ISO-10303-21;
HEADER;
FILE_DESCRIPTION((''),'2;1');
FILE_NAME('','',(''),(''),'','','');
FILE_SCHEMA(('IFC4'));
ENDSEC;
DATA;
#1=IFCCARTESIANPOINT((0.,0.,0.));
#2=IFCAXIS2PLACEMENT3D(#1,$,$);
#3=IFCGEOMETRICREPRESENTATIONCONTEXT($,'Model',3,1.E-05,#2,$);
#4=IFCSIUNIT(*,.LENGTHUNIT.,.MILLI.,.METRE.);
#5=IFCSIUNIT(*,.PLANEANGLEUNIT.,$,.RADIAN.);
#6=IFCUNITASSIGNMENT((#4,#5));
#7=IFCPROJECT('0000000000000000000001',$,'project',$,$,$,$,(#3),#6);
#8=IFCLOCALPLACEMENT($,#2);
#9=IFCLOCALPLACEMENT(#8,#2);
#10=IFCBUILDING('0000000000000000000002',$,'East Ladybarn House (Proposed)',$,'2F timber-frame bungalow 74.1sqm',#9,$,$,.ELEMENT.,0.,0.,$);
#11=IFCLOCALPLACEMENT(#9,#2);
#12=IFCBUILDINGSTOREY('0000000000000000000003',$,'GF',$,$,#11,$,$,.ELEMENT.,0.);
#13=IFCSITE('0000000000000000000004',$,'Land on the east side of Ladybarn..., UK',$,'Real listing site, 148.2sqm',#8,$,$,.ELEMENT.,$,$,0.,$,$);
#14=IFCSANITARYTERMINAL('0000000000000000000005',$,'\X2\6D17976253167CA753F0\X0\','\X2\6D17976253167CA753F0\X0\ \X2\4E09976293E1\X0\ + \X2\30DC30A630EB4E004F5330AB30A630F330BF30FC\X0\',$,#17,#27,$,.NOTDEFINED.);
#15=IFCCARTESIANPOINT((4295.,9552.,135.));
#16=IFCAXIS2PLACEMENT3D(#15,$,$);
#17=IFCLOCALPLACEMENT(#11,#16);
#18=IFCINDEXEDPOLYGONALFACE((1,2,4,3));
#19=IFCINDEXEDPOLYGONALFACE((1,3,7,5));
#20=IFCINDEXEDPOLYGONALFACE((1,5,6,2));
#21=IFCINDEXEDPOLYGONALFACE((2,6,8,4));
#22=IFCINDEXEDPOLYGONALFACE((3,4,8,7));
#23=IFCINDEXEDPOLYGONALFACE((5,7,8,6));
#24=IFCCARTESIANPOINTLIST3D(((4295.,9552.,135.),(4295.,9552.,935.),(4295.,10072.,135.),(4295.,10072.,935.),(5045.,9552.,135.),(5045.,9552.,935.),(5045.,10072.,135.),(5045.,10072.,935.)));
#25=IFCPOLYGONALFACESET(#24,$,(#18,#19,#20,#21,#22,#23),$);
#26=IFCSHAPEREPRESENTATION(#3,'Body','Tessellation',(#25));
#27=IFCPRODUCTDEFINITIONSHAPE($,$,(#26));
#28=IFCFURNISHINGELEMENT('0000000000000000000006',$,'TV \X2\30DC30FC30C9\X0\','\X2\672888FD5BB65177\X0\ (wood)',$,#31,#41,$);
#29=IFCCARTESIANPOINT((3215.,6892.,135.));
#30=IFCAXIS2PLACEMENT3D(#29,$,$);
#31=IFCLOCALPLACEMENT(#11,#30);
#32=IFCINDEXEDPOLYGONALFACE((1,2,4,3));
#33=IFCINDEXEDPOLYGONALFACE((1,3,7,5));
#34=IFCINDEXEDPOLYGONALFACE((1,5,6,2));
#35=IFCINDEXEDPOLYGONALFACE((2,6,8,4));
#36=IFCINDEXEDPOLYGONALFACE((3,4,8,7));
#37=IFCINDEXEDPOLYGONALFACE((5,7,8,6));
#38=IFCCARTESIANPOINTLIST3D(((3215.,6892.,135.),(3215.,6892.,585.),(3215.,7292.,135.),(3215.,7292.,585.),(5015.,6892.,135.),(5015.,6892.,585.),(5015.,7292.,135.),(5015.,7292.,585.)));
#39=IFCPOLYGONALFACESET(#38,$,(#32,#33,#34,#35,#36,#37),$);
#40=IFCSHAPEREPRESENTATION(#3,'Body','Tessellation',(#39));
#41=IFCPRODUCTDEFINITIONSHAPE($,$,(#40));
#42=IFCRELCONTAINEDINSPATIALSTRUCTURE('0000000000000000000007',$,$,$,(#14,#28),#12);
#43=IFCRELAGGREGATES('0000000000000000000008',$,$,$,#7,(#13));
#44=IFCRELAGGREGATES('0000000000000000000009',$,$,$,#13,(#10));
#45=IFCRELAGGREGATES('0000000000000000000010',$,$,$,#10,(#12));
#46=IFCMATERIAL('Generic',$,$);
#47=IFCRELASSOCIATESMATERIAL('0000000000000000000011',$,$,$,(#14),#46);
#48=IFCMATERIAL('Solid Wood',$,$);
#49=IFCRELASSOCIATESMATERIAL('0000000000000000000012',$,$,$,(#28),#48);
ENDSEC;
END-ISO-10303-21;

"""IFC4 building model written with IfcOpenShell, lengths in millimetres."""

from ifc_helpers import new_model, si_unit, frame, frame_2d, origin, place, context, project, spatial, rectangle, extrude, material, element, save


model = new_model("IFC4")

# Units and contexts
model_context = context("Model", 3, precision=1e-05, world=origin())
ifc_project = project(units=[si_unit("LENGTHUNIT", "METRE", prefix="MILLI"), si_unit("PLANEANGLEUNIT", "RADIAN")], contexts=[model_context])

# Site, building, storey
site_placement = place(None, origin())
site = spatial("IfcSite", under=ifc_project, at=site_placement, Name="Land on the east side of Ladybarn..., UK", ObjectType="Real listing site, 148.2sqm", CompositionType="ELEMENT", RefElevation=0.0)
building_placement = place(site_placement, origin())
building = spatial("IfcBuilding", under=site, at=building_placement, Name="East Ladybarn House (Proposed)", ObjectType="2F timber-frame bungalow 74.1sqm", CompositionType="ELEMENT", ElevationOfRefHeight=0.0, ElevationOfTerrain=0.0)
storey_placement = place(building_placement, origin())
storey = spatial("IfcBuildingStorey", under=building, at=storey_placement, Name="GF", CompositionType="ELEMENT", Elevation=0.0)

# Shared definitions
ifc_material_1 = material(Name="Solid Wood")

# Shared definitions
ifc_material_2 = material(Name="Generic")

# Sanitary terminal
sanitary_terminal_1_placement = place(storey_placement, frame((4295.0, 9552.0, 135.0)))
element("IfcSanitaryTerminal", 1, at=sanitary_terminal_1_placement, inside=storey, material=ifc_material_2, Name="洗面化粧台", Description="洗面化粧台 三面鏡 + ボウル一体カウンター", PredefinedType="NOTDEFINED", context=model_context, shape_type="SweptSolid", body=[
    extrude(rectangle(XDim=750.0, YDim=520.0, at=frame_2d((375.0, 260.0))), frame((4295.0, 9552.0, 135.0)), (0.0, 0.0, 1.0), 800.0),
])

# Furnishing element
furnishing_placement = place(storey_placement, frame((3215.0, 6892.0, 135.0)))
element("IfcFurnishingElement", 2, at=furnishing_placement, inside=storey, material=ifc_material_1, Name="TV ボード", Description="木製家具 (wood)", context=model_context, shape_type="SweptSolid", body=[
    extrude(rectangle(XDim=1800.0, YDim=400.0, at=frame_2d((900.0, 200.0))), frame((3215.0, 6892.0, 135.0)), (0.0, 0.0, 1.0), 450.0),
])

save(model, "model.ifc")
